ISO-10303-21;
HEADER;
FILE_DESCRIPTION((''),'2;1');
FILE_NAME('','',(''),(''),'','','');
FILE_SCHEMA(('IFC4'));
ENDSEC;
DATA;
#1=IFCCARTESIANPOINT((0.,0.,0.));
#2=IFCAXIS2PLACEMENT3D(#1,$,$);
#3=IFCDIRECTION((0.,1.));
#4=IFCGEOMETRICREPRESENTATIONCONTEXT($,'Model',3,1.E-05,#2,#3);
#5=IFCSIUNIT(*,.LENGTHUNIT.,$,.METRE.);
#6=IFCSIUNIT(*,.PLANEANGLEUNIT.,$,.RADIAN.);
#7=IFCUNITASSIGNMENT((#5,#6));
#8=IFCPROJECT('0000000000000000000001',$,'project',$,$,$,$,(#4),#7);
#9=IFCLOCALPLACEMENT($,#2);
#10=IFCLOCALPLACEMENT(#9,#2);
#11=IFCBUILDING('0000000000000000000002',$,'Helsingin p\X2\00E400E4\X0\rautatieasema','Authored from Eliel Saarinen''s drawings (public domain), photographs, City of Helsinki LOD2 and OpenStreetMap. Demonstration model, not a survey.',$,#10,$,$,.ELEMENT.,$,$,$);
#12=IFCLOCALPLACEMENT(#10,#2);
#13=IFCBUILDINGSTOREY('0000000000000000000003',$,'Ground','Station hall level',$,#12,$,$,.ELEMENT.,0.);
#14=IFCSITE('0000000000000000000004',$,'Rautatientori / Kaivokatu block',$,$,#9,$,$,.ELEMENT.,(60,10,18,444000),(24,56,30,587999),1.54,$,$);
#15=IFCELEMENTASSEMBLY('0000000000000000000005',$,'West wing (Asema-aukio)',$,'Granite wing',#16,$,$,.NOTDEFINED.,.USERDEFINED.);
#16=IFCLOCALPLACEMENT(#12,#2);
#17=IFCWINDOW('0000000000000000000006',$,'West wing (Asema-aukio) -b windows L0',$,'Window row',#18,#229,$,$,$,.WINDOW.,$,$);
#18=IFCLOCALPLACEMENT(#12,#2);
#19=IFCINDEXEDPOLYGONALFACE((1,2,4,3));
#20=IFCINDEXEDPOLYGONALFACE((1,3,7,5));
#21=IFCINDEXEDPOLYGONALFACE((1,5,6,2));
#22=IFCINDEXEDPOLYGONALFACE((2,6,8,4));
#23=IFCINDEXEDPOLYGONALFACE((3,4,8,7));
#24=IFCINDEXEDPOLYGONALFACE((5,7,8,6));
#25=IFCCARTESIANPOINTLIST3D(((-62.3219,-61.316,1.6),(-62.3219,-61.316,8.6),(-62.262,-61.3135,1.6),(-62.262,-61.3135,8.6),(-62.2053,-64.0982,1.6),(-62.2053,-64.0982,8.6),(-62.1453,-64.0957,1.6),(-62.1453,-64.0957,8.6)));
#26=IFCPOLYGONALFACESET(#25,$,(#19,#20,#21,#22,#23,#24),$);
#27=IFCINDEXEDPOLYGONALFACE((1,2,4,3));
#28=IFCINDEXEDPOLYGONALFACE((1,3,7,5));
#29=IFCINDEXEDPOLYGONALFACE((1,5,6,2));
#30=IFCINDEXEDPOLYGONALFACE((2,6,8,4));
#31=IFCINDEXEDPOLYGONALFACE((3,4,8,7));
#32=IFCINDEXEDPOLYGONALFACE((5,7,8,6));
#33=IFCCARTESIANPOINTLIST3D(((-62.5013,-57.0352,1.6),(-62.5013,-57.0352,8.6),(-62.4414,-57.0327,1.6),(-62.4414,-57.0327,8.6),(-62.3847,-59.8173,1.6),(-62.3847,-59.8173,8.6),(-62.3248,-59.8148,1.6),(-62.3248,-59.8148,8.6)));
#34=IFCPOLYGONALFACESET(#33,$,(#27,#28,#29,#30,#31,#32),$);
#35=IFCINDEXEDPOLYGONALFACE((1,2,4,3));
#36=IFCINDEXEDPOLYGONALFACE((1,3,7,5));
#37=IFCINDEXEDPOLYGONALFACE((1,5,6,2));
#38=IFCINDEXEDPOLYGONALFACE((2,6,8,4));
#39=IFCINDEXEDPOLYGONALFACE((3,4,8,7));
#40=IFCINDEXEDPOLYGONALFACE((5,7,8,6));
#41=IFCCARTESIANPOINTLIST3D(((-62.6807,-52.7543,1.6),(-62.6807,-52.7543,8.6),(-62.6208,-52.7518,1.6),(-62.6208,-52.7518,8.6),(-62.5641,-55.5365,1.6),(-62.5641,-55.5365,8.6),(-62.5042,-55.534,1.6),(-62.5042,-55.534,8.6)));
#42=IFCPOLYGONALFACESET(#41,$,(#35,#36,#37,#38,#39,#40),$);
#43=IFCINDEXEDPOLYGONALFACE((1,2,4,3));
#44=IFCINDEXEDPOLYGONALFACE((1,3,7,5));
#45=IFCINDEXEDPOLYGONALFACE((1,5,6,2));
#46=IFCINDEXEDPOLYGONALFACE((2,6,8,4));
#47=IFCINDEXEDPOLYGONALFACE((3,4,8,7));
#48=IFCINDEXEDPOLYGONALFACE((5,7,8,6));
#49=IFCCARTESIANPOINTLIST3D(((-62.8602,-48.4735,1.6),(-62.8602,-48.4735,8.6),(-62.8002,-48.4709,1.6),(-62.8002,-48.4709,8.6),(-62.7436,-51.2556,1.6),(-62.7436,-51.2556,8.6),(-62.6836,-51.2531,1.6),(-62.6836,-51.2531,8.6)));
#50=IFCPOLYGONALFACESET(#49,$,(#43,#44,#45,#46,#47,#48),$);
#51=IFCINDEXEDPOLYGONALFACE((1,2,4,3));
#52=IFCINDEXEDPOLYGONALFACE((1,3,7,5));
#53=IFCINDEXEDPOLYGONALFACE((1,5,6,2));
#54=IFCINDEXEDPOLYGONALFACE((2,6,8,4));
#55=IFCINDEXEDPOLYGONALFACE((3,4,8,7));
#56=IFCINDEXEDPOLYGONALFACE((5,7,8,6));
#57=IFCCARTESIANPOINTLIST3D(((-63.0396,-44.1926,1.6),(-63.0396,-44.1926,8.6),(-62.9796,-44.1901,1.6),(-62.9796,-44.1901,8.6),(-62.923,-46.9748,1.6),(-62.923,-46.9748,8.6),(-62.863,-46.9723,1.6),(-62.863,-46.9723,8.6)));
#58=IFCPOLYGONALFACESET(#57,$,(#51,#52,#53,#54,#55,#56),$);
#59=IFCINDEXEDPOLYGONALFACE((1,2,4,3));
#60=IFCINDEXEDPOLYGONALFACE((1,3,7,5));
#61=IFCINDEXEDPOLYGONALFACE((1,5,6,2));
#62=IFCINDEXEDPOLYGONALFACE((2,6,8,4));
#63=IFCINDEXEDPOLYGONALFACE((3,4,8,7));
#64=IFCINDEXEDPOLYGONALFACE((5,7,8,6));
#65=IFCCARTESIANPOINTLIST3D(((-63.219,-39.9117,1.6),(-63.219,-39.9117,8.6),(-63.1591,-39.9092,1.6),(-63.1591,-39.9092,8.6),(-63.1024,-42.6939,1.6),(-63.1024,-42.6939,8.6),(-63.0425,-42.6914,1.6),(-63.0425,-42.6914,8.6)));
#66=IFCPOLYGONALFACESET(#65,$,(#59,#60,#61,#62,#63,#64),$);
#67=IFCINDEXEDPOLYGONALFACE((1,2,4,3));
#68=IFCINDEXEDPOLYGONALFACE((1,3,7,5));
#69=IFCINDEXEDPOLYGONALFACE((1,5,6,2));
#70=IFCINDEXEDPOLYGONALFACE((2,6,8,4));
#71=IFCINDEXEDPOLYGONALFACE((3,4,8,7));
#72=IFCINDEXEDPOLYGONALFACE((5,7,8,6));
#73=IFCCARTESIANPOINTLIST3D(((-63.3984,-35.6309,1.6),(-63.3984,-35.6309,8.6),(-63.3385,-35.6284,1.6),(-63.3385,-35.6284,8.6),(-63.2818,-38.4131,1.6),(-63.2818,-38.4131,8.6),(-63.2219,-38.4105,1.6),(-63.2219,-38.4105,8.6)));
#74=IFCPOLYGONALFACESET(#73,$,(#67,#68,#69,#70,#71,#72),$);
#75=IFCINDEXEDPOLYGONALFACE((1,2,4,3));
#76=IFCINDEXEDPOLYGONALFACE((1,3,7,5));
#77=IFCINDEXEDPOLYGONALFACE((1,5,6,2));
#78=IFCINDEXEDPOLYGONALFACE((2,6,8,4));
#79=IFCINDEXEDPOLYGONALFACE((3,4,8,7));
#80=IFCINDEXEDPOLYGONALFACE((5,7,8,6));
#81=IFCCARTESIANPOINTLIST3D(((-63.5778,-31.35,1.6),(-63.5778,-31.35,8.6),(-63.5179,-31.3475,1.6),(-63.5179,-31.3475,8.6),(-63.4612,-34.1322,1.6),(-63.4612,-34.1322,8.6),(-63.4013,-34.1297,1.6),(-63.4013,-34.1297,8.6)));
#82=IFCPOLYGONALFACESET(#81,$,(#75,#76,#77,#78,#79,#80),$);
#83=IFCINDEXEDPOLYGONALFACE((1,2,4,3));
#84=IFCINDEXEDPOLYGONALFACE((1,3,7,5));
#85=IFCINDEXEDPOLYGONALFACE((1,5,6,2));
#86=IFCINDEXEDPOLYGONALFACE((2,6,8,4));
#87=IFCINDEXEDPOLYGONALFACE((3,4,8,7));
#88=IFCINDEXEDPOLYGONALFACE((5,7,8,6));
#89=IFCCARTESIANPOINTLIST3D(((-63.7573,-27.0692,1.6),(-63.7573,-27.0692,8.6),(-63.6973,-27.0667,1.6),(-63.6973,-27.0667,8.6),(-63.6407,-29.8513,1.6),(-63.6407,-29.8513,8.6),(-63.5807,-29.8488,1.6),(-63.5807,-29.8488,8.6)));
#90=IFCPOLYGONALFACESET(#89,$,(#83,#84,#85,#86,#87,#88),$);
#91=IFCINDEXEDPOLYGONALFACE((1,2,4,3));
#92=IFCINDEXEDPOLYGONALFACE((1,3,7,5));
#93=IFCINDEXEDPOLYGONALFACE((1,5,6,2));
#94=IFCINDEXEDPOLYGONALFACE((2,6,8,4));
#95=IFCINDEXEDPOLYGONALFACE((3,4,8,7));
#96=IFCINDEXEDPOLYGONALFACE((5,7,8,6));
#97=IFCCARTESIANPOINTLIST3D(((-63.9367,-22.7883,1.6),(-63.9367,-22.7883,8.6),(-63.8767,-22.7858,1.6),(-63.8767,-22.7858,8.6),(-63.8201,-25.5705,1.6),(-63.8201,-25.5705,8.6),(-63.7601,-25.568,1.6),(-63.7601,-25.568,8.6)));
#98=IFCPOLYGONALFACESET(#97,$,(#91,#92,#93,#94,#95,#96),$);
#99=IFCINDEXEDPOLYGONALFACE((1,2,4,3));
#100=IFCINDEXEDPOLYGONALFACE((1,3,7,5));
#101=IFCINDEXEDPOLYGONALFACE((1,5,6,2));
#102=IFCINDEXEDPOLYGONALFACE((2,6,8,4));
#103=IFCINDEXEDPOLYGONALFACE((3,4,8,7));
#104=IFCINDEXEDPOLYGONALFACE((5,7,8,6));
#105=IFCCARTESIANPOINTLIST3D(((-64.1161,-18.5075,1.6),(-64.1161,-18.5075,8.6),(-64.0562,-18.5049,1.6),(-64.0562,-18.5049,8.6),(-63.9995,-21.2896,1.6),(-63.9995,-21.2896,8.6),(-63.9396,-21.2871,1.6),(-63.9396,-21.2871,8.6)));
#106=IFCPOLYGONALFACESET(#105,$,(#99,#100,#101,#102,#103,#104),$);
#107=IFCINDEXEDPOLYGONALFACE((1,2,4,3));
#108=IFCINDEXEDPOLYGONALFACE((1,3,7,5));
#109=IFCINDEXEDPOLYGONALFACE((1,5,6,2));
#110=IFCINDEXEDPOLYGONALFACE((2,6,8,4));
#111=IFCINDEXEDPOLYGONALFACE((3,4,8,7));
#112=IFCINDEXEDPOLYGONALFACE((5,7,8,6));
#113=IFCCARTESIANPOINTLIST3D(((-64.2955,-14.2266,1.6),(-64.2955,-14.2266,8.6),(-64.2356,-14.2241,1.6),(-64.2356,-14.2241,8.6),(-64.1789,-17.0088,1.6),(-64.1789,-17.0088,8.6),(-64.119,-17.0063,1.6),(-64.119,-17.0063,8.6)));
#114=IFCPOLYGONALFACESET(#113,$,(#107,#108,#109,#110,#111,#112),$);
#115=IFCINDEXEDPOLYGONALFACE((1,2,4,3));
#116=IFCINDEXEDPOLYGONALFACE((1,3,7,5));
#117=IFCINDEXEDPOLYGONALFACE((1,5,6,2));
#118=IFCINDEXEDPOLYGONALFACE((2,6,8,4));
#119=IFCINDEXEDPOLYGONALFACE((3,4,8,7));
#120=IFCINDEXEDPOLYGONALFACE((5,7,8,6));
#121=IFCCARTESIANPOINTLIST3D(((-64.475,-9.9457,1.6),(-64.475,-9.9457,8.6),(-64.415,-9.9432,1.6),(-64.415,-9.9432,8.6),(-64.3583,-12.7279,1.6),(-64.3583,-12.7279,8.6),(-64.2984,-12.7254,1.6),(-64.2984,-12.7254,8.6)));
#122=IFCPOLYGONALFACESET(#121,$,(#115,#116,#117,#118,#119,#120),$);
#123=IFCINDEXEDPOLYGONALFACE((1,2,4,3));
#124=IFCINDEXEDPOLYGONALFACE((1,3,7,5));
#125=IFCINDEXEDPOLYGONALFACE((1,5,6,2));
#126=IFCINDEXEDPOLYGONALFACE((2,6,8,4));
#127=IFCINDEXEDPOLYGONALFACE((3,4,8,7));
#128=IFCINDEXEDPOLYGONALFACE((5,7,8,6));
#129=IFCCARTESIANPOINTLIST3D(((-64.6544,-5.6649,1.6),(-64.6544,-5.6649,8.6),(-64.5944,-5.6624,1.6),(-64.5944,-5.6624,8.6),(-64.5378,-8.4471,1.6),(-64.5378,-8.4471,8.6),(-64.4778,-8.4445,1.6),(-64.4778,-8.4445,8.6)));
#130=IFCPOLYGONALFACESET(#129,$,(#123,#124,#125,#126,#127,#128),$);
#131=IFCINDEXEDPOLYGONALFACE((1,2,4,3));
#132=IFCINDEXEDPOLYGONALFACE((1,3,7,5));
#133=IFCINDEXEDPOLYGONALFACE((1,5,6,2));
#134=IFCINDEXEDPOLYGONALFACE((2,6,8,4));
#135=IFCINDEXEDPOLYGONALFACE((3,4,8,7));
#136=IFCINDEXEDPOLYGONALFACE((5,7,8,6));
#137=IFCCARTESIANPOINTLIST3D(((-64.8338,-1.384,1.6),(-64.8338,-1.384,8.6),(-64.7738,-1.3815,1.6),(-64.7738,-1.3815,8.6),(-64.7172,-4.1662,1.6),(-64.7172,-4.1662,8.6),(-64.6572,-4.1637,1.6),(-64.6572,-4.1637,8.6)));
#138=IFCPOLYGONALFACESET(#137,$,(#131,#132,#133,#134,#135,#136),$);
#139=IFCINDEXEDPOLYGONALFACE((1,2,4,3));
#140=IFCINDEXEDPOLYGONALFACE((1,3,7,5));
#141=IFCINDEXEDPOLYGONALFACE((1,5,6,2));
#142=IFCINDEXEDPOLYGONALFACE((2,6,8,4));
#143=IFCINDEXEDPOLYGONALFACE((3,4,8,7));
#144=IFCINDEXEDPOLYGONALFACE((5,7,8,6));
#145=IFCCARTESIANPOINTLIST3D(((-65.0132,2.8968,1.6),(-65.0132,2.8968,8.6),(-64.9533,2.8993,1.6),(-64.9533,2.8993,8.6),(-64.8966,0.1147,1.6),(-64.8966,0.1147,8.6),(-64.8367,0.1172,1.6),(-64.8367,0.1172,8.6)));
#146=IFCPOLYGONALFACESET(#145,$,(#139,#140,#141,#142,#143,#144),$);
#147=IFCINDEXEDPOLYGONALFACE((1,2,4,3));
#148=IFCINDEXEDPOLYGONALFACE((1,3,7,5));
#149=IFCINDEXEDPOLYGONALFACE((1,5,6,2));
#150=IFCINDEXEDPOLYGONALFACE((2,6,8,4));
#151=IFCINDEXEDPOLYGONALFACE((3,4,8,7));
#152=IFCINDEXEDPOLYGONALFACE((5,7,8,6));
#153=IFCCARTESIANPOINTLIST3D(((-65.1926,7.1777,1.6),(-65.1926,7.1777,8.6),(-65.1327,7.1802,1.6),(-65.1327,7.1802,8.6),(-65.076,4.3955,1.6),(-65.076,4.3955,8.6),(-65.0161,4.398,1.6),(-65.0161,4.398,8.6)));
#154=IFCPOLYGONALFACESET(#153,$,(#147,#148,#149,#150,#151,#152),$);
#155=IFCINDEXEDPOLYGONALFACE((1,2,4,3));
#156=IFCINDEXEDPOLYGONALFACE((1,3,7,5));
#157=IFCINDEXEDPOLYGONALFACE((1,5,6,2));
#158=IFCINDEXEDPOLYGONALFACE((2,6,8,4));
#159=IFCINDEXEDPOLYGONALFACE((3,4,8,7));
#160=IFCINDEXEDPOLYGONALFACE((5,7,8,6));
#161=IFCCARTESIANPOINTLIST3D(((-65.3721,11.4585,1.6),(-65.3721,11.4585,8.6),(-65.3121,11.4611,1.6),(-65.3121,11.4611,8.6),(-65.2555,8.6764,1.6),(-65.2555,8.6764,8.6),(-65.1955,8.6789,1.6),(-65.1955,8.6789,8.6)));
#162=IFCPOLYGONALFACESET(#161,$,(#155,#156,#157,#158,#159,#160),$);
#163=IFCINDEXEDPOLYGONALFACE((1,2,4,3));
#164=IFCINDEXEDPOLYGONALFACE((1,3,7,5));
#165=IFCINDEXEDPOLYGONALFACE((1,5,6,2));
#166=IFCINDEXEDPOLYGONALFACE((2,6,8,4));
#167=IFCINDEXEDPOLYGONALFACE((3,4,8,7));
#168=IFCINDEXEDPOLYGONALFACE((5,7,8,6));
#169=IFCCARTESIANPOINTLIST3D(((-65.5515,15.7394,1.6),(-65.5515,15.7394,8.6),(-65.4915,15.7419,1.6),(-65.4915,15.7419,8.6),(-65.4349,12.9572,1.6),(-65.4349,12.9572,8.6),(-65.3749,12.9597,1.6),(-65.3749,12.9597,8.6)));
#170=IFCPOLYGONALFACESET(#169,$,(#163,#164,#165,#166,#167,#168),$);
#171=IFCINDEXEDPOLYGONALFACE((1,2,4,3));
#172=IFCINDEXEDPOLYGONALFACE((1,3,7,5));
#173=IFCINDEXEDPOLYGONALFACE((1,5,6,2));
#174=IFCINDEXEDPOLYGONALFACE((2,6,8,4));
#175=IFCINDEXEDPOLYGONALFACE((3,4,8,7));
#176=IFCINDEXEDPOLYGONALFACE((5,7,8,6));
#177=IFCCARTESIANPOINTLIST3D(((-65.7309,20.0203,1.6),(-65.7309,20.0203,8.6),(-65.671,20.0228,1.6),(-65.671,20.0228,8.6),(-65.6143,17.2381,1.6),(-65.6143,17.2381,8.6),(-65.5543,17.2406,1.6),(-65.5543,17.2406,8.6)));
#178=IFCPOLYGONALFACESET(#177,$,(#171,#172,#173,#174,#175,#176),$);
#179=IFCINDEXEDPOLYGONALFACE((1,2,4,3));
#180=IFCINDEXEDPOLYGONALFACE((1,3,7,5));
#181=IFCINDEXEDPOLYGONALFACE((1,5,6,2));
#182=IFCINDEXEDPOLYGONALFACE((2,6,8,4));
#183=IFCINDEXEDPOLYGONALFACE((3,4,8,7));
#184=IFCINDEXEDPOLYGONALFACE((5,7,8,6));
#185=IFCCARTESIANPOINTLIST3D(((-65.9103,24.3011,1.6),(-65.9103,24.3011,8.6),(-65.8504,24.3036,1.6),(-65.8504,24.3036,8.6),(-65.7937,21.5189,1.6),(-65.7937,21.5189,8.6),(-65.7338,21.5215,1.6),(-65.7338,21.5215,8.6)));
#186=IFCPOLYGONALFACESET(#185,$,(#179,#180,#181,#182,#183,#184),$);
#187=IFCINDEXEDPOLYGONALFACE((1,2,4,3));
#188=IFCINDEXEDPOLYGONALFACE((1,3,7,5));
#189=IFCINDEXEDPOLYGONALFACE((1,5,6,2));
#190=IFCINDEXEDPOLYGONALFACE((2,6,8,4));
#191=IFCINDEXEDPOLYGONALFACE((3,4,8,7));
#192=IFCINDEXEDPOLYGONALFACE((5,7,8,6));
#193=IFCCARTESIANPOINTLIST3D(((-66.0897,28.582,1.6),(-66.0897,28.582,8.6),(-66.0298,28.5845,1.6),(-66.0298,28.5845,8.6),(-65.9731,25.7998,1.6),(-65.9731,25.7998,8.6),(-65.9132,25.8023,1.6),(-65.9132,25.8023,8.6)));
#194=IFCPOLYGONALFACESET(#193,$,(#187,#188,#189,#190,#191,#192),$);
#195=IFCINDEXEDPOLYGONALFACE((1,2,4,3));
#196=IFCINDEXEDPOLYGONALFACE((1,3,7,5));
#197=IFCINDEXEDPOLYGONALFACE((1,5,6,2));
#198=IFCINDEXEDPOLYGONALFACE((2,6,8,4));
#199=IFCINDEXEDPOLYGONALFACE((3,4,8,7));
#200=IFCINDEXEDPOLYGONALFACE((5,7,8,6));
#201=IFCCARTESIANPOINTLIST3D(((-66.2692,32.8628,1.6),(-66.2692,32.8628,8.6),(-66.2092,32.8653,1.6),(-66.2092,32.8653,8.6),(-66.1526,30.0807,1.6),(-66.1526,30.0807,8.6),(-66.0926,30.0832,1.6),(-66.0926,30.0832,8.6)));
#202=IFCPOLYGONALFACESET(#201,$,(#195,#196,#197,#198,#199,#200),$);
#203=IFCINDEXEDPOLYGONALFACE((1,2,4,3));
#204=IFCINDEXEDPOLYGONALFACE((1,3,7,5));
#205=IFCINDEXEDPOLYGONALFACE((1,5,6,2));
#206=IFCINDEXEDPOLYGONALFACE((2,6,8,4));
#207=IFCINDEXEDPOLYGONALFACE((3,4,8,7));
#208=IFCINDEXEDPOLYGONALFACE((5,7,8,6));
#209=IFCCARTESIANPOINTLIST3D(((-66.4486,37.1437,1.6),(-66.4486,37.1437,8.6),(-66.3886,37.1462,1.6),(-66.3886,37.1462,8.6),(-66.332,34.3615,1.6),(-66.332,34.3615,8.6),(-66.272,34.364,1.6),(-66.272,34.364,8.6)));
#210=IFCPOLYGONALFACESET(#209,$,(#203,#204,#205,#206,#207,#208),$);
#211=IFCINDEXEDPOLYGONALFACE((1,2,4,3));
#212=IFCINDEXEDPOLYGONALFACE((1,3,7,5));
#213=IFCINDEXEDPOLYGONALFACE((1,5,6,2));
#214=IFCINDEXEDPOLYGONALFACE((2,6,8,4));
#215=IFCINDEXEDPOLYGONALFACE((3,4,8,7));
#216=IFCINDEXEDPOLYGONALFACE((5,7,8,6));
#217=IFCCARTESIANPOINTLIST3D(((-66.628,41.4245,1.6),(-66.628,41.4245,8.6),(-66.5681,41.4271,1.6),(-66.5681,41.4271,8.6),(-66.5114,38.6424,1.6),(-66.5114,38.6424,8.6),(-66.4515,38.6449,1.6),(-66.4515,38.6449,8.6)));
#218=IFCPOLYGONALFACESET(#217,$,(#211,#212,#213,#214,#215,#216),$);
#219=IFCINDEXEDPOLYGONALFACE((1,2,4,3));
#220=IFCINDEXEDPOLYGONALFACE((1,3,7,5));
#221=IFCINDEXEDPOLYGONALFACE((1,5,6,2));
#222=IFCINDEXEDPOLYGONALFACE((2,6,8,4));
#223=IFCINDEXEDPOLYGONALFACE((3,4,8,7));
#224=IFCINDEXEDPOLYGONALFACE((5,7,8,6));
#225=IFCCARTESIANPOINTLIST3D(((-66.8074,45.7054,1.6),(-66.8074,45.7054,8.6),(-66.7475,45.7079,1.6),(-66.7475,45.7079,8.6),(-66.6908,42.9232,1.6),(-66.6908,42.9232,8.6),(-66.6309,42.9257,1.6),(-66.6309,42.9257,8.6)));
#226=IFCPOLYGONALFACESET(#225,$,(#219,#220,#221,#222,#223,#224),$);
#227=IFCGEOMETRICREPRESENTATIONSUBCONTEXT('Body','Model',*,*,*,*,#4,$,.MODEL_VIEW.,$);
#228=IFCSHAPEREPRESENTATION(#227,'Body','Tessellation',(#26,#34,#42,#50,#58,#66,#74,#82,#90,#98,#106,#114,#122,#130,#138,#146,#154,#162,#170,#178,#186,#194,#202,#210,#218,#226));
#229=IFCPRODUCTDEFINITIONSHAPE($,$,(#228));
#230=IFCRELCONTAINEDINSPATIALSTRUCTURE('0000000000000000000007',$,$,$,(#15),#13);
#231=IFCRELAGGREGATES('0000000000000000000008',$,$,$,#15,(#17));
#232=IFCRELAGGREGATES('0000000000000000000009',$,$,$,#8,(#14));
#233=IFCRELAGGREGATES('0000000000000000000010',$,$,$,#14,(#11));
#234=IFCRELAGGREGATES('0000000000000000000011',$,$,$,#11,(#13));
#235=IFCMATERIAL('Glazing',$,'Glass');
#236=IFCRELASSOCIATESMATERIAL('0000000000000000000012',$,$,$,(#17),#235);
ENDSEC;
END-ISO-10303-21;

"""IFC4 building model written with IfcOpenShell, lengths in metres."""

from ifc_helpers import new_model, si_unit, direction, frame, frame_2d, origin, place, context, subcontext, project, spatial, rectangle, extrude, material, element, aggregate, save


model = new_model("IFC4")

# Units and contexts
model_context = context("Model", 3, precision=1e-05, world=origin(), true_north=direction((0.0, 1.0)))
body_context = subcontext(model_context, "Body", "Model", "MODEL_VIEW")
ifc_project = project(units=[si_unit("LENGTHUNIT", "METRE"), si_unit("PLANEANGLEUNIT", "RADIAN")], contexts=[model_context])

# Site, building, storey
site_placement = place(None, origin())
site = spatial("IfcSite", under=ifc_project, at=site_placement, Name="Rautatientori / Kaivokatu block", CompositionType="ELEMENT", RefLatitude=(60, 10, 18, 444000), RefLongitude=(24, 56, 30, 587999), RefElevation=1.54)
building_placement = place(site_placement, origin())
building = spatial("IfcBuilding", under=site, at=building_placement, Name="Helsingin päärautatieasema", Description="Authored from Eliel Saarinen's drawings (public domain), photographs, City of Helsinki LOD2 and OpenStreetMap. Demonstration model, not a survey.", CompositionType="ELEMENT")
storey_placement = place(building_placement, origin())
storey = spatial("IfcBuildingStorey", under=building, at=storey_placement, Name="Ground", Description="Station hall level", CompositionType="ELEMENT", Elevation=0.0)

# Element assembly, window
assembly_placement = place(building_placement, origin())
assembly = element("IfcElementAssembly", 1, at=assembly_placement, inside=storey, Name="West wing (Asema-aukio)", ObjectType="Granite wing", AssemblyPlace="NOTDEFINED", PredefinedType="USERDEFINED")
ifc_material_1 = material(Name="Glazing", Category="Glass")
window_1_placement = place(building_placement, origin())
window_1 = element("IfcWindow", 2, at=window_1_placement, material=ifc_material_1, Name="West wing (Asema-aukio) -b windows L0", ObjectType="Window row", PredefinedType="WINDOW", context=body_context, shape_type="SweptSolid", body=[
    extrude(rectangle(XDim=2.7846, YDim=0.06, at=frame_2d((0.0, 0.0), x_axis=(-0.041876, 0.999123))), frame((-62.2336, -62.7059, 1.6)), (0.0, 0.0, 1.0), 7.0),
    extrude(rectangle(XDim=2.7846, YDim=0.06, at=frame_2d((0.0, 0.0), x_axis=(-0.041876, 0.999123))), frame((-62.413, -58.425, 1.6)), (0.0, 0.0, 1.0), 7.0),
    extrude(rectangle(XDim=2.7846, YDim=0.06, at=frame_2d((0.0, 0.0), x_axis=(-0.041876, 0.999123))), frame((-62.5925, -54.1441, 1.6)), (0.0, 0.0, 1.0), 7.0),
    extrude(rectangle(XDim=2.7846, YDim=0.06, at=frame_2d((0.0, 0.0), x_axis=(-0.041876, 0.999123))), frame((-62.7719, -49.8633, 1.6)), (0.0, 0.0, 1.0), 7.0),
    extrude(rectangle(XDim=2.7846, YDim=0.06, at=frame_2d((0.0, 0.0), x_axis=(-0.041876, 0.999123))), frame((-62.9513, -45.5824, 1.6)), (0.0, 0.0, 1.0), 7.0),
    extrude(rectangle(XDim=2.7846, YDim=0.06, at=frame_2d((0.0, 0.0), x_axis=(-0.041876, 0.999123))), frame((-63.1307, -41.3016, 1.6)), (0.0, 0.0, 1.0), 7.0),
    extrude(rectangle(XDim=2.7846, YDim=0.06, at=frame_2d((0.0, 0.0), x_axis=(-0.041876, 0.999123))), frame((-63.3101, -37.0207, 1.6)), (0.0, 0.0, 1.0), 7.0),
    extrude(rectangle(XDim=2.7846, YDim=0.06, at=frame_2d((0.0, 0.0), x_axis=(-0.041876, 0.999123))), frame((-63.4896, -32.7399, 1.6)), (0.0, 0.0, 1.0), 7.0),
    extrude(rectangle(XDim=2.7846, YDim=0.06, at=frame_2d((0.0, 0.0), x_axis=(-0.041876, 0.999123))), frame((-63.669, -28.459, 1.6)), (0.0, 0.0, 1.0), 7.0),
    extrude(rectangle(XDim=2.7846, YDim=0.06, at=frame_2d((0.0, 0.0), x_axis=(-0.041876, 0.999123))), frame((-63.8484, -24.1781, 1.6)), (0.0, 0.0, 1.0), 7.0),
    extrude(rectangle(XDim=2.7846, YDim=0.06, at=frame_2d((0.0, 0.0), x_axis=(-0.041876, 0.999123))), frame((-64.0278, -19.8973, 1.6)), (0.0, 0.0, 1.0), 7.0),
    extrude(rectangle(XDim=2.7846, YDim=0.06, at=frame_2d((0.0, 0.0), x_axis=(-0.041876, 0.999123))), frame((-64.2073, -15.6164, 1.6)), (0.0, 0.0, 1.0), 7.0),
    extrude(rectangle(XDim=2.7846, YDim=0.06, at=frame_2d((0.0, 0.0), x_axis=(-0.041876, 0.999123))), frame((-64.3867, -11.3356, 1.6)), (0.0, 0.0, 1.0), 7.0),
    extrude(rectangle(XDim=2.7846, YDim=0.06, at=frame_2d((0.0, 0.0), x_axis=(-0.041876, 0.999123))), frame((-64.5661, -7.0547, 1.6)), (0.0, 0.0, 1.0), 7.0),
    extrude(rectangle(XDim=2.7846, YDim=0.06, at=frame_2d((0.0, 0.0), x_axis=(-0.041876, 0.999123))), frame((-64.7455, -2.7739, 1.6)), (0.0, 0.0, 1.0), 7.0),
    extrude(rectangle(XDim=2.7846, YDim=0.06, at=frame_2d((0.0, 0.0), x_axis=(-0.041876, 0.999123))), frame((-64.9249, 1.507, 1.6)), (0.0, 0.0, 1.0), 7.0),
    extrude(rectangle(XDim=2.7846, YDim=0.06, at=frame_2d((0.0, 0.0), x_axis=(-0.041876, 0.999123))), frame((-65.1044, 5.7879, 1.6)), (0.0, 0.0, 1.0), 7.0),
    extrude(rectangle(XDim=2.7846, YDim=0.06, at=frame_2d((0.0, 0.0), x_axis=(-0.041876, 0.999123))), frame((-65.2838, 10.0687, 1.6)), (0.0, 0.0, 1.0), 7.0),
    extrude(rectangle(XDim=2.7846, YDim=0.06, at=frame_2d((0.0, 0.0), x_axis=(-0.041876, 0.999123))), frame((-65.4632, 14.3496, 1.6)), (0.0, 0.0, 1.0), 7.0),
    extrude(rectangle(XDim=2.7846, YDim=0.06, at=frame_2d((0.0, 0.0), x_axis=(-0.041876, 0.999123))), frame((-65.6426, 18.6304, 1.6)), (0.0, 0.0, 1.0), 7.0),
    extrude(rectangle(XDim=2.7846, YDim=0.06, at=frame_2d((0.0, 0.0), x_axis=(-0.041876, 0.999123))), frame((-65.822, 22.9113, 1.6)), (0.0, 0.0, 1.0), 7.0),
    extrude(rectangle(XDim=2.7846, YDim=0.06, at=frame_2d((0.0, 0.0), x_axis=(-0.041876, 0.999123))), frame((-66.0015, 27.1921, 1.6)), (0.0, 0.0, 1.0), 7.0),
    extrude(rectangle(XDim=2.7846, YDim=0.06, at=frame_2d((0.0, 0.0), x_axis=(-0.041876, 0.999123))), frame((-66.1809, 31.473, 1.6)), (0.0, 0.0, 1.0), 7.0),
    extrude(rectangle(XDim=2.7846, YDim=0.06, at=frame_2d((0.0, 0.0), x_axis=(-0.041876, 0.999123))), frame((-66.3603, 35.7539, 1.6)), (0.0, 0.0, 1.0), 7.0),
    extrude(rectangle(XDim=2.7846, YDim=0.06, at=frame_2d((0.0, 0.0), x_axis=(-0.041876, 0.999123))), frame((-66.5397, 40.0347, 1.6)), (0.0, 0.0, 1.0), 7.0),
    extrude(rectangle(XDim=2.7846, YDim=0.06, at=frame_2d((0.0, 0.0), x_axis=(-0.041876, 0.999123))), frame((-66.7191, 44.3156, 1.6)), (0.0, 0.0, 1.0), 7.0),
])
aggregate(assembly, [window_1])

save(model, "model.ifc")
